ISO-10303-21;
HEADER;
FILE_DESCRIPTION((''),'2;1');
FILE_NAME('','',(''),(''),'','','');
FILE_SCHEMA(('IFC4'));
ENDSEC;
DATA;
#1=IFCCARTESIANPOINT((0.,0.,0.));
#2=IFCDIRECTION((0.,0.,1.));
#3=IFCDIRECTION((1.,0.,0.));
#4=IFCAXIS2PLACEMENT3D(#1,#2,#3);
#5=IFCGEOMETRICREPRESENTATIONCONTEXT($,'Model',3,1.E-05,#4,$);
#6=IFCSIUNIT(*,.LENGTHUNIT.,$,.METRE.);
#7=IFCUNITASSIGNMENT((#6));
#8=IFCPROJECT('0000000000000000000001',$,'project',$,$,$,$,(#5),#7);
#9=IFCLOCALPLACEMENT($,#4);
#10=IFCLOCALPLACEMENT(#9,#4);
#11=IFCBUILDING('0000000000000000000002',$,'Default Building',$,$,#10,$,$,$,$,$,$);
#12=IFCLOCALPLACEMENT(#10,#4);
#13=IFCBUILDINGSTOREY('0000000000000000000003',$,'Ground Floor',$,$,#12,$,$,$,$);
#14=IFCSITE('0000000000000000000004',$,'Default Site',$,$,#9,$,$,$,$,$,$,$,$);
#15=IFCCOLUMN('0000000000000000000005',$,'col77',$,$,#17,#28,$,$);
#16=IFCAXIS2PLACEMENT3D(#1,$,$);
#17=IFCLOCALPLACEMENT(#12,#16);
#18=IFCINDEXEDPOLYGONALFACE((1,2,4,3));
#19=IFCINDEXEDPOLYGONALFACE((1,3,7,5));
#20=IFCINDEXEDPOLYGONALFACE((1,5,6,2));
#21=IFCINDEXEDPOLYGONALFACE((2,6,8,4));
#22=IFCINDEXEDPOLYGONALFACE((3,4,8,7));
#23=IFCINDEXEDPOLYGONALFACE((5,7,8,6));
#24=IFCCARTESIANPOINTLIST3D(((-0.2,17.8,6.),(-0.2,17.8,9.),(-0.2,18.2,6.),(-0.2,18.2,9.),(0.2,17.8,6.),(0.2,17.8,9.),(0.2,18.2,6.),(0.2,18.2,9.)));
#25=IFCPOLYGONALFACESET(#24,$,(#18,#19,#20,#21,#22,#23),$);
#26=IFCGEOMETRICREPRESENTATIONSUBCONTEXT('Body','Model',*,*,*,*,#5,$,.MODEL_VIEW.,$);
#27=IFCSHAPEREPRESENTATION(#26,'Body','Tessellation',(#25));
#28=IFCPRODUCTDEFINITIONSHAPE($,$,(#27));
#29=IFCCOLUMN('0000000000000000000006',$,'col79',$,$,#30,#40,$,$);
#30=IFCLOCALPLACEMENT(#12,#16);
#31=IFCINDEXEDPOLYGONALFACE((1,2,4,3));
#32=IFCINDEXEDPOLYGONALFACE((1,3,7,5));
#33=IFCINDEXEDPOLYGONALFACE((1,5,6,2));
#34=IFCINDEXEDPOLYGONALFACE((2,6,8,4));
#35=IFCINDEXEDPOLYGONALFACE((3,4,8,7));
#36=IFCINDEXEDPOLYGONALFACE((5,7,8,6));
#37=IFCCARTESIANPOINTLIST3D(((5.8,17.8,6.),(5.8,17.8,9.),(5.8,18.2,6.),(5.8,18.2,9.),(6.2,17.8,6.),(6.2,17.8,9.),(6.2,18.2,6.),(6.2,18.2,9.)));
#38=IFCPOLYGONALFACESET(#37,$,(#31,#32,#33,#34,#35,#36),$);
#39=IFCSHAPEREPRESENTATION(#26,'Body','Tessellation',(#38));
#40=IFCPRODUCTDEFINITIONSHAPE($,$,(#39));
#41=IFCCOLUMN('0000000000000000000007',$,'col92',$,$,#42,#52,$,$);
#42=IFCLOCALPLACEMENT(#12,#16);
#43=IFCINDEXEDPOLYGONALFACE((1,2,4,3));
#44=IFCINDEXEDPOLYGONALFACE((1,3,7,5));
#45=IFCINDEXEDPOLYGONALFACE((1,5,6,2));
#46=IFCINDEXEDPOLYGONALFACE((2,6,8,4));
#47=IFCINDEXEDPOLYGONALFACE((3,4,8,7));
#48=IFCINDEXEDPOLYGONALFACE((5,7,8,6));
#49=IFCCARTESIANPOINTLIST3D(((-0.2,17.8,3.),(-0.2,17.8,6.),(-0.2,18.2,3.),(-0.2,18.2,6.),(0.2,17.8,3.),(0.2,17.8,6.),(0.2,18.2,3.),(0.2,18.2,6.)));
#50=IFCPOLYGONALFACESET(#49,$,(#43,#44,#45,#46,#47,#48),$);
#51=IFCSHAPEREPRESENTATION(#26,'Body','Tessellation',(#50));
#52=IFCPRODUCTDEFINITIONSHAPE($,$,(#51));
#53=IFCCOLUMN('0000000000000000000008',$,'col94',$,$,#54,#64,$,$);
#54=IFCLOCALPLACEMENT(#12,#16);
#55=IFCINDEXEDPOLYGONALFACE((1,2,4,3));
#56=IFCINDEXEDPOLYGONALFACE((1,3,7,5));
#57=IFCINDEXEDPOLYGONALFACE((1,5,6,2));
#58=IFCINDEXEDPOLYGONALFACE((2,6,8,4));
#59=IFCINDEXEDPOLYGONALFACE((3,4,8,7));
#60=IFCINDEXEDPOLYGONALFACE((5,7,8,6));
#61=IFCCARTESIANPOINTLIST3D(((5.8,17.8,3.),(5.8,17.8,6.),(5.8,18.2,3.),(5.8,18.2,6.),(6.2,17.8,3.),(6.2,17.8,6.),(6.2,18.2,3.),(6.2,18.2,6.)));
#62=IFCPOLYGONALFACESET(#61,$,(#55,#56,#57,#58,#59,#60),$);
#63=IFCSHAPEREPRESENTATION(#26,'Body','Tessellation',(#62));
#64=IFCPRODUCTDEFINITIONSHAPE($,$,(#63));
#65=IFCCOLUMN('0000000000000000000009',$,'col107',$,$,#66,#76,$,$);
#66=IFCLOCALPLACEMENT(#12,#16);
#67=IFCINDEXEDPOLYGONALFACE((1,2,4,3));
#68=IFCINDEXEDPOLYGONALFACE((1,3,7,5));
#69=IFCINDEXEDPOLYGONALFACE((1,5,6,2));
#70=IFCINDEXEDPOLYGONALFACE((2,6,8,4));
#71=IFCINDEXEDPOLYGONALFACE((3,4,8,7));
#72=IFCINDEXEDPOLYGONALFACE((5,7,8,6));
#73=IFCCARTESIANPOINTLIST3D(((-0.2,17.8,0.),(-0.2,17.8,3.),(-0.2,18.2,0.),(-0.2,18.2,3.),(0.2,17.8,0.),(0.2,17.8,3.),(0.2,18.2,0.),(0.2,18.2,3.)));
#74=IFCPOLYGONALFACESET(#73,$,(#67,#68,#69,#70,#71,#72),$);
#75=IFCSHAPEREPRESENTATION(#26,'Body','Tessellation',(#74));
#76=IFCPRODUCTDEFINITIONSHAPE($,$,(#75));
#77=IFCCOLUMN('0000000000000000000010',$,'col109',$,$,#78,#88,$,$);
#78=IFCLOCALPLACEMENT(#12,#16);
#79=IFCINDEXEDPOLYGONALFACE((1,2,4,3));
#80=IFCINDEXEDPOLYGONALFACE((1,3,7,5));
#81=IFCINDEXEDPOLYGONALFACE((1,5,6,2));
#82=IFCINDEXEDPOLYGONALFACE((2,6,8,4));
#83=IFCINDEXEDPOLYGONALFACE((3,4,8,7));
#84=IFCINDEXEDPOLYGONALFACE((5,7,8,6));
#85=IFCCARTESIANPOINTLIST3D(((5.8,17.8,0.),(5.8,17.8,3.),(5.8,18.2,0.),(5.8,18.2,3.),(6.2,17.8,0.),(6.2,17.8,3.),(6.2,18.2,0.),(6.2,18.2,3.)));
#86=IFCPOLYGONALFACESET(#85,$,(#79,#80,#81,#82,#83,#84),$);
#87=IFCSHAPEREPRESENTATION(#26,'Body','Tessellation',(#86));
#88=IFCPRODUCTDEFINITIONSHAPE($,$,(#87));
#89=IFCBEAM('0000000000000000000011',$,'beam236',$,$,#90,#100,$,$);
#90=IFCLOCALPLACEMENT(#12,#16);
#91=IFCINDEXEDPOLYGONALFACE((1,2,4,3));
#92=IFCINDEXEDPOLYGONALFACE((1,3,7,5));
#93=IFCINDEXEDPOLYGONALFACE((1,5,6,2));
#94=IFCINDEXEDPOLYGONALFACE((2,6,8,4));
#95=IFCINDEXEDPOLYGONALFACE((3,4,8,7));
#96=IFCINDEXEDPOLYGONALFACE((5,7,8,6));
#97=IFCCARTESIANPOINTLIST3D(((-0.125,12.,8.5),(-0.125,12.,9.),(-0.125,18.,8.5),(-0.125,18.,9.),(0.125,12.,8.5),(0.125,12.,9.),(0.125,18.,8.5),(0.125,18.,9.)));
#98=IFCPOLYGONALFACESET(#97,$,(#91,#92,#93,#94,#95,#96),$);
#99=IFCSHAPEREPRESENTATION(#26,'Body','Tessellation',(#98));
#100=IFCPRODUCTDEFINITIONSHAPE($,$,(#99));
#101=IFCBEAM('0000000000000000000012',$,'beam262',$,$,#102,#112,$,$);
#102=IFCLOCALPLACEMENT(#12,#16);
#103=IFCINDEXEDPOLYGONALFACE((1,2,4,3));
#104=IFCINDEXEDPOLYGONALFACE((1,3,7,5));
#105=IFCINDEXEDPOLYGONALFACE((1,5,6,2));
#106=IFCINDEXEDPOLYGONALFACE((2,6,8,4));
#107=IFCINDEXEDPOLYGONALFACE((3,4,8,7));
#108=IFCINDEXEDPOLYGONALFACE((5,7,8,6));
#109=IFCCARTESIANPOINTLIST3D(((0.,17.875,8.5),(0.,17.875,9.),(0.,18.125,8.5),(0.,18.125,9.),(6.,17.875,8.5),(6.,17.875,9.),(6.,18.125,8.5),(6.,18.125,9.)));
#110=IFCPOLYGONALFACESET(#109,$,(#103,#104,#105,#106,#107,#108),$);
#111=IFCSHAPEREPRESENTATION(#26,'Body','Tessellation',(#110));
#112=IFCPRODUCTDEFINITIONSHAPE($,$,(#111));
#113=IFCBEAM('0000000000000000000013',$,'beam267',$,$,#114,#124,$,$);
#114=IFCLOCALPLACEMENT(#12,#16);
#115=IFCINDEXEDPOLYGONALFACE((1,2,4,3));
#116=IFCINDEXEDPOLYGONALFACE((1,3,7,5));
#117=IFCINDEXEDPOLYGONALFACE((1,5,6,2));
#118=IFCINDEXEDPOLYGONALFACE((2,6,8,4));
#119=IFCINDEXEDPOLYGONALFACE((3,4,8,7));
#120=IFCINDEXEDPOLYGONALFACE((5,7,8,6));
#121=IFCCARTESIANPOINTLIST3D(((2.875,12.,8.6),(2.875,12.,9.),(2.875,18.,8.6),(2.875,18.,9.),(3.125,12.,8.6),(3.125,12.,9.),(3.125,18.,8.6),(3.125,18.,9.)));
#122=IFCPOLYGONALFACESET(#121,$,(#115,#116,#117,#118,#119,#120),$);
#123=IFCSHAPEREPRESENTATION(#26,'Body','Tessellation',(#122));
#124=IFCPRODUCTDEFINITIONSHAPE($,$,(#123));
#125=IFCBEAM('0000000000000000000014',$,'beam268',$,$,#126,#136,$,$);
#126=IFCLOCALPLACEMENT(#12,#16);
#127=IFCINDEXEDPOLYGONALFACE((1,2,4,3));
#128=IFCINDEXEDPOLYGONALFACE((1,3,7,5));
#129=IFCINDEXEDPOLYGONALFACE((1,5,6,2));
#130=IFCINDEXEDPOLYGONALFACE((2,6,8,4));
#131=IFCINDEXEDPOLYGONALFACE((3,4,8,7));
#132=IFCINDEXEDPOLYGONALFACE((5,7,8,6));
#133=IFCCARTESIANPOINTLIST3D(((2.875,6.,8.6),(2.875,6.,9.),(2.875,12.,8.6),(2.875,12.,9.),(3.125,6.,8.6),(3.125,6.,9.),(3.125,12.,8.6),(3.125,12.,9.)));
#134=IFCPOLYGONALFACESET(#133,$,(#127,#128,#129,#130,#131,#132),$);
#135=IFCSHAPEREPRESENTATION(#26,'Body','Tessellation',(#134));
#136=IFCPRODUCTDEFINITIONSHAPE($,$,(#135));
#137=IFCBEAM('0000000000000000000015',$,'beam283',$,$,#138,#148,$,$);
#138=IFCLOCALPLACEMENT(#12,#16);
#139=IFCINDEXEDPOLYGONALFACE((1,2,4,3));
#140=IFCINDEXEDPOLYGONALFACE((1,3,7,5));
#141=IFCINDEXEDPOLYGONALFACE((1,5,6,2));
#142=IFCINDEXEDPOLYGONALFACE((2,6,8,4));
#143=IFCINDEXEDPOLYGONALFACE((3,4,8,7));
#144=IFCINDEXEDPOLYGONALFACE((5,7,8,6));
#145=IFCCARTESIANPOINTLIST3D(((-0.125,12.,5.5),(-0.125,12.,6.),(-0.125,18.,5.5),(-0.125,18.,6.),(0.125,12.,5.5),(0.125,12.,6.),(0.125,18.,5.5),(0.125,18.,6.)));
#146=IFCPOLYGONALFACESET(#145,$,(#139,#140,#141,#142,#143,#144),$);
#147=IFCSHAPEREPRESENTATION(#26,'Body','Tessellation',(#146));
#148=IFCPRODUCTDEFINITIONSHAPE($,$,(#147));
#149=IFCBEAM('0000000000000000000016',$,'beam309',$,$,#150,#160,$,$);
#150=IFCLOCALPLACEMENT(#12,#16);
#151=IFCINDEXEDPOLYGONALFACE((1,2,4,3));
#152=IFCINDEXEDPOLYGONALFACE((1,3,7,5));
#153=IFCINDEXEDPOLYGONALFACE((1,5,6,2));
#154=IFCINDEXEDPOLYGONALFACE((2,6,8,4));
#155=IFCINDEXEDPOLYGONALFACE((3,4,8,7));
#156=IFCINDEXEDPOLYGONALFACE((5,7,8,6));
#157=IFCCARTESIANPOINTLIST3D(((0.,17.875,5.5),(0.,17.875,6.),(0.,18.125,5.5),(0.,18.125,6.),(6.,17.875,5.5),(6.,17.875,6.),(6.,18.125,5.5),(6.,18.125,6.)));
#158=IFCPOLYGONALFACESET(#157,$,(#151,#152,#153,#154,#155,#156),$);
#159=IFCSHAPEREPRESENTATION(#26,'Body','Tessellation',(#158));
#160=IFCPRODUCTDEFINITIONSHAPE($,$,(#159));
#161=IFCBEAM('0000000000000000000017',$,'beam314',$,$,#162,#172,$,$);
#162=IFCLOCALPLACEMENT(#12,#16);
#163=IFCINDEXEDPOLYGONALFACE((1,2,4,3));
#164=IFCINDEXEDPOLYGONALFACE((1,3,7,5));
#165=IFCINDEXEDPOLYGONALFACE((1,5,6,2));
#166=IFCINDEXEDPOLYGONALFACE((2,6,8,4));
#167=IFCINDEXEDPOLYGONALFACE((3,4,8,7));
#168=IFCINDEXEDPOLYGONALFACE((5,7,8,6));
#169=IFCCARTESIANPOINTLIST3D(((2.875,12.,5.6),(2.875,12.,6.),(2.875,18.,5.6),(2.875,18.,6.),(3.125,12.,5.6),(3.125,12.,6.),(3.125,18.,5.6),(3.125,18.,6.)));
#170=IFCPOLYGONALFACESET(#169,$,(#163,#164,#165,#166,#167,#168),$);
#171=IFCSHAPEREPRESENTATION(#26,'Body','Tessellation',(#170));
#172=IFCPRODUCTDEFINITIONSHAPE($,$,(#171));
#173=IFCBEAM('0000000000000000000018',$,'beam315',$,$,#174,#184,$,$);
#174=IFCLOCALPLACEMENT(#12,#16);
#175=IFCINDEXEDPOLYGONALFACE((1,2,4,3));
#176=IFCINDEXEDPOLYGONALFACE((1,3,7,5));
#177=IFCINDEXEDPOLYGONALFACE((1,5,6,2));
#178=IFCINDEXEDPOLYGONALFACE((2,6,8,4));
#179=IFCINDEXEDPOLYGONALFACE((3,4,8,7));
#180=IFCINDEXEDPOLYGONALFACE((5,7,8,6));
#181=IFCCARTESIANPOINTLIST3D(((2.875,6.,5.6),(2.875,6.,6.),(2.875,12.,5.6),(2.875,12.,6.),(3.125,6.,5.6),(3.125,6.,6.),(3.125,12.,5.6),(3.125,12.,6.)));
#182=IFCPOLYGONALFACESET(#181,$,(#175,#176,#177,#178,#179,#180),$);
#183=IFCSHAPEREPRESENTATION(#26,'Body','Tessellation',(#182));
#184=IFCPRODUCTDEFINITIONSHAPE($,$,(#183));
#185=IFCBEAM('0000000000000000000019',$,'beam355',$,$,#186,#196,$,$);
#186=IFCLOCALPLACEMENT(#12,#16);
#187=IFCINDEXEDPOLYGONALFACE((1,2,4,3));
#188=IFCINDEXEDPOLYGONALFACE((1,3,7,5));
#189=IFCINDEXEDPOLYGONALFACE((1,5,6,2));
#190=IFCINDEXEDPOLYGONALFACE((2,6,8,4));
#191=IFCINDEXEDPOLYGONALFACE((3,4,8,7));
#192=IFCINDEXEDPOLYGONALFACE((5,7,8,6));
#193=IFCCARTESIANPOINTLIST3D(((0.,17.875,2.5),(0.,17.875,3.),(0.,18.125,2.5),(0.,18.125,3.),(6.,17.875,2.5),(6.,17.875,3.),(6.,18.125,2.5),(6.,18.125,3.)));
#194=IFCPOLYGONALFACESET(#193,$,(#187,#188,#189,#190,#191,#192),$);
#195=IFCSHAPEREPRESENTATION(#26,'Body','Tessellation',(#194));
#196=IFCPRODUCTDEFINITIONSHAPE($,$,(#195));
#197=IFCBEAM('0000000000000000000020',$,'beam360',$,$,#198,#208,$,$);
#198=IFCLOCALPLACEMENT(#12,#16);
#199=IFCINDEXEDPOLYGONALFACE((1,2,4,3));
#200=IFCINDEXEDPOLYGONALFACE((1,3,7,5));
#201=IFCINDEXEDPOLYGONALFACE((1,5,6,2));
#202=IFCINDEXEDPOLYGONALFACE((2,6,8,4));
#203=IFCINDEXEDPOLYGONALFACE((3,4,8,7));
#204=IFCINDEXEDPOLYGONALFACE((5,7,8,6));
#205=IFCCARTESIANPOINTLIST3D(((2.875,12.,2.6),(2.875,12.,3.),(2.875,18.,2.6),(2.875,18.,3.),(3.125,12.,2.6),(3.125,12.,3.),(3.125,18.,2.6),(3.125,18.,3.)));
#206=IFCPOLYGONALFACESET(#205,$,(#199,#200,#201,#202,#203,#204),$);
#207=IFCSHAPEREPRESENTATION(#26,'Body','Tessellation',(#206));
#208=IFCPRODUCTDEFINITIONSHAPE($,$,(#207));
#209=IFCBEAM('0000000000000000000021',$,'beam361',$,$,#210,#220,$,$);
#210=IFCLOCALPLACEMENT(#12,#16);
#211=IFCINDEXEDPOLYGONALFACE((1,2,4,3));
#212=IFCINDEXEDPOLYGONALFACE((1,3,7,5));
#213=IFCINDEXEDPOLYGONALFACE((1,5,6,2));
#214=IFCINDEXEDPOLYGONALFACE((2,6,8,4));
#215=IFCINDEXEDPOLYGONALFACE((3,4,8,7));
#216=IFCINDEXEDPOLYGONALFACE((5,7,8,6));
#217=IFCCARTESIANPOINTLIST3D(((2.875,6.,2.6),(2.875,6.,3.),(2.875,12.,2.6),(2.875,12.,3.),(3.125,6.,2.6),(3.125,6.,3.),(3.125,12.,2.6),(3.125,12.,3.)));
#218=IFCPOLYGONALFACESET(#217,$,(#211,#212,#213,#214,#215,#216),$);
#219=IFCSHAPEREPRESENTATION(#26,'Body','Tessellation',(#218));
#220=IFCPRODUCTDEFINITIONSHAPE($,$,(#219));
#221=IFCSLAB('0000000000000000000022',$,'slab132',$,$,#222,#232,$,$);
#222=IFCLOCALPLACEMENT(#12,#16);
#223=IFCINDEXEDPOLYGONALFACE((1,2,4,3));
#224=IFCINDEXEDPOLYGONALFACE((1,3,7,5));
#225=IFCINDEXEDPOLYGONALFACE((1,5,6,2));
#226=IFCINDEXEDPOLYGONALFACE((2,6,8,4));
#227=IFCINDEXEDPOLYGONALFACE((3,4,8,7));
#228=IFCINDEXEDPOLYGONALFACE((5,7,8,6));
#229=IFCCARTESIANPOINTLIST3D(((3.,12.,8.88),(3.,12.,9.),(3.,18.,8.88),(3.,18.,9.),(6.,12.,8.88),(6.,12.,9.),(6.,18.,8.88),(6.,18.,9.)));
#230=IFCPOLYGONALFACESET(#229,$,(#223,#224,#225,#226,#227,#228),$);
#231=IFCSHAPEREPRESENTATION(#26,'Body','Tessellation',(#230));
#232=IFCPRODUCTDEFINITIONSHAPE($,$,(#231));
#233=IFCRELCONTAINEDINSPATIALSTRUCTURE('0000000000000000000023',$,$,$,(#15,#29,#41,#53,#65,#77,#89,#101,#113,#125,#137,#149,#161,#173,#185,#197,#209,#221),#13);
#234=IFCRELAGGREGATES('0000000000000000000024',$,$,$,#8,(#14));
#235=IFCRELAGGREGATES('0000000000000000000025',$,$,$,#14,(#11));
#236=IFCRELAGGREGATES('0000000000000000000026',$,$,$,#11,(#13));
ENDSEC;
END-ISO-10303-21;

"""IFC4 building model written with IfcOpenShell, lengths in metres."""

from ifc_helpers import new_model, si_unit, frame, origin_with_axes, place, context, subcontext, project, spatial, indexed_curve, outline, extrude, element, save


model = new_model("IFC4")

# Units and contexts
model_context = context("Model", 3, precision=1e-05, world=origin_with_axes())
body_context = subcontext(model_context, "Body", "Model", "MODEL_VIEW")
ifc_project = project(units=[si_unit("LENGTHUNIT", "METRE")], contexts=[model_context])

# Site, building, storey
site_placement = place(None, origin_with_axes())
site = spatial("IfcSite", under=ifc_project, at=site_placement, Name="Default Site")
building_placement = place(site_placement, origin_with_axes())
building = spatial("IfcBuilding", under=site, at=building_placement, Name="Default Building")
storey_placement = place(building_placement, origin_with_axes())
storey = spatial("IfcBuildingStorey", under=building, at=storey_placement, Name="Ground Floor")

# Columns
for number, where, z_axis, x_axis, name in (
    (1, (-0.2, 17.8, 6.0), (0.0, 0.0, 1.0), (1.0, 0.0, 0.0), "col77"),
    (2, (5.8, 17.8, 6.0), (0.0, 0.0, 1.0), (1.0, 0.0, 0.0), "col79"),
    (3, (-0.2, 17.8, 3.0), (0.0, 0.0, 1.0), (1.0, 0.0, 0.0), "col92"),
    (4, (5.8, 17.8, 3.0), (0.0, 0.0, 1.0), (1.0, 0.0, 0.0), "col94"),
    (5, (-0.2, 17.8, 0.0), (0.0, 0.0, 1.0), (1.0, 0.0, 0.0), "col107"),
    (6, (5.8, 17.8, 0.0), (0.0, 0.0, 1.0), (1.0, 0.0, 0.0), "col109"),
):
    element("IfcColumn", number, at=place(storey_placement, frame(where, z_axis=z_axis, x_axis=x_axis)), inside=storey, Name=name, context=body_context, shape_type="SweptSolid", body=[
        extrude(outline(indexed_curve([(0.0, 0.0), (0.0, 0.4), (0.4, 0.4), (0.4, 0.0), (0.0, 0.0)], self_intersect=False)), origin_with_axes(), (0.0, 0.0, 1.0), 3.0),
    ])

# Beams
for number, where, z_axis, x_axis, name in (
    (7, (0.125, 12.0, 8.5), (0.0, 0.0, 1.0), (0.0, 1.0, 0.0), "beam236"),
    (8, (0.0, 17.875, 8.5), (0.0, 0.0, 1.0), (1.0, 0.0, 0.0), "beam262"),
):
    element("IfcBeam", number, at=place(storey_placement, frame(where, z_axis=z_axis, x_axis=x_axis)), inside=storey, Name=name, context=body_context, shape_type="SweptSolid", body=[
        extrude(outline(indexed_curve([(0.0, 0.0), (0.0, 0.25), (6.0, 0.25), (6.0, 0.0), (0.0, 0.0)], self_intersect=False)), origin_with_axes(), (0.0, 0.0, 1.0), 0.5),
    ])
for number, where, z_axis, x_axis, name in (
    (9, (2.875, 18.0, 8.6), (0.0, 0.0, 1.0), (0.0, -1.0, 0.0), "beam267"),
    (10, (2.875, 12.0, 8.6), (0.0, 0.0, 1.0), (0.0, -1.0, 0.0), "beam268"),
):
    element("IfcBeam", number, at=place(storey_placement, frame(where, z_axis=z_axis, x_axis=x_axis)), inside=storey, Name=name, context=body_context, shape_type="SweptSolid", body=[
        extrude(outline(indexed_curve([(0.0, 0.0), (0.0, 0.25), (6.0, 0.25), (6.0, 0.0), (0.0, 0.0)], self_intersect=False)), origin_with_axes(), (0.0, 0.0, 1.0), 0.4),
    ])
for number, where, z_axis, x_axis, name in (
    (11, (0.125, 12.0, 5.5), (0.0, 0.0, 1.0), (0.0, 1.0, 0.0), "beam283"),
    (12, (0.0, 17.875, 5.5), (0.0, 0.0, 1.0), (1.0, 0.0, 0.0), "beam309"),
):
    element("IfcBeam", number, at=place(storey_placement, frame(where, z_axis=z_axis, x_axis=x_axis)), inside=storey, Name=name, context=body_context, shape_type="SweptSolid", body=[
        extrude(outline(indexed_curve([(0.0, 0.0), (0.0, 0.25), (6.0, 0.25), (6.0, 0.0), (0.0, 0.0)], self_intersect=False)), origin_with_axes(), (0.0, 0.0, 1.0), 0.5),
    ])
for number, where, z_axis, x_axis, name in (
    (13, (2.875, 18.0, 5.6), (0.0, 0.0, 1.0), (0.0, -1.0, 0.0), "beam314"),
    (14, (2.875, 12.0, 5.6), (0.0, 0.0, 1.0), (0.0, -1.0, 0.0), "beam315"),
):
    element("IfcBeam", number, at=place(storey_placement, frame(where, z_axis=z_axis, x_axis=x_axis)), inside=storey, Name=name, context=body_context, shape_type="SweptSolid", body=[
        extrude(outline(indexed_curve([(0.0, 0.0), (0.0, 0.25), (6.0, 0.25), (6.0, 0.0), (0.0, 0.0)], self_intersect=False)), origin_with_axes(), (0.0, 0.0, 1.0), 0.4),
    ])
beam_placement = place(storey_placement, frame((0.0, 17.875, 2.5), z_axis=(0.0, 0.0, 1.0), x_axis=(1.0, 0.0, 0.0)))
element("IfcBeam", 15, at=beam_placement, inside=storey, Name="beam355", context=body_context, shape_type="SweptSolid", body=[
    extrude(outline(indexed_curve([(0.0, 0.0), (0.0, 0.25), (6.0, 0.25), (6.0, 0.0), (0.0, 0.0)], self_intersect=False)), origin_with_axes(), (0.0, 0.0, 1.0), 0.5),
])
for number, where, z_axis, x_axis, name in (
    (16, (2.875, 18.0, 2.6), (0.0, 0.0, 1.0), (0.0, -1.0, 0.0), "beam360"),
    (17, (2.875, 12.0, 2.6), (0.0, 0.0, 1.0), (0.0, -1.0, 0.0), "beam361"),
):
    element("IfcBeam", number, at=place(storey_placement, frame(where, z_axis=z_axis, x_axis=x_axis)), inside=storey, Name=name, context=body_context, shape_type="SweptSolid", body=[
        extrude(outline(indexed_curve([(0.0, 0.0), (0.0, 0.25), (6.0, 0.25), (6.0, 0.0), (0.0, 0.0)], self_intersect=False)), origin_with_axes(), (0.0, 0.0, 1.0), 0.4),
    ])

# Slab
for number, where, z_axis, x_axis, name in (
    (18, (3.0, 12.0, 8.88), (0.0, 0.0, 1.0), (1.0, 0.0, 0.0), "slab132"),
):
    element("IfcSlab", number, at=place(storey_placement, frame(where, z_axis=z_axis, x_axis=x_axis)), inside=storey, Name=name, context=body_context, shape_type="SweptSolid", body=[
        extrude(outline(indexed_curve([(0.0, 0.0), (0.0, 6.0), (3.0, 6.0), (3.0, 0.0), (0.0, 0.0)], self_intersect=False)), origin_with_axes(), (0.0, 0.0, 1.0), 0.12),
    ])

save(model, "model.ifc")
